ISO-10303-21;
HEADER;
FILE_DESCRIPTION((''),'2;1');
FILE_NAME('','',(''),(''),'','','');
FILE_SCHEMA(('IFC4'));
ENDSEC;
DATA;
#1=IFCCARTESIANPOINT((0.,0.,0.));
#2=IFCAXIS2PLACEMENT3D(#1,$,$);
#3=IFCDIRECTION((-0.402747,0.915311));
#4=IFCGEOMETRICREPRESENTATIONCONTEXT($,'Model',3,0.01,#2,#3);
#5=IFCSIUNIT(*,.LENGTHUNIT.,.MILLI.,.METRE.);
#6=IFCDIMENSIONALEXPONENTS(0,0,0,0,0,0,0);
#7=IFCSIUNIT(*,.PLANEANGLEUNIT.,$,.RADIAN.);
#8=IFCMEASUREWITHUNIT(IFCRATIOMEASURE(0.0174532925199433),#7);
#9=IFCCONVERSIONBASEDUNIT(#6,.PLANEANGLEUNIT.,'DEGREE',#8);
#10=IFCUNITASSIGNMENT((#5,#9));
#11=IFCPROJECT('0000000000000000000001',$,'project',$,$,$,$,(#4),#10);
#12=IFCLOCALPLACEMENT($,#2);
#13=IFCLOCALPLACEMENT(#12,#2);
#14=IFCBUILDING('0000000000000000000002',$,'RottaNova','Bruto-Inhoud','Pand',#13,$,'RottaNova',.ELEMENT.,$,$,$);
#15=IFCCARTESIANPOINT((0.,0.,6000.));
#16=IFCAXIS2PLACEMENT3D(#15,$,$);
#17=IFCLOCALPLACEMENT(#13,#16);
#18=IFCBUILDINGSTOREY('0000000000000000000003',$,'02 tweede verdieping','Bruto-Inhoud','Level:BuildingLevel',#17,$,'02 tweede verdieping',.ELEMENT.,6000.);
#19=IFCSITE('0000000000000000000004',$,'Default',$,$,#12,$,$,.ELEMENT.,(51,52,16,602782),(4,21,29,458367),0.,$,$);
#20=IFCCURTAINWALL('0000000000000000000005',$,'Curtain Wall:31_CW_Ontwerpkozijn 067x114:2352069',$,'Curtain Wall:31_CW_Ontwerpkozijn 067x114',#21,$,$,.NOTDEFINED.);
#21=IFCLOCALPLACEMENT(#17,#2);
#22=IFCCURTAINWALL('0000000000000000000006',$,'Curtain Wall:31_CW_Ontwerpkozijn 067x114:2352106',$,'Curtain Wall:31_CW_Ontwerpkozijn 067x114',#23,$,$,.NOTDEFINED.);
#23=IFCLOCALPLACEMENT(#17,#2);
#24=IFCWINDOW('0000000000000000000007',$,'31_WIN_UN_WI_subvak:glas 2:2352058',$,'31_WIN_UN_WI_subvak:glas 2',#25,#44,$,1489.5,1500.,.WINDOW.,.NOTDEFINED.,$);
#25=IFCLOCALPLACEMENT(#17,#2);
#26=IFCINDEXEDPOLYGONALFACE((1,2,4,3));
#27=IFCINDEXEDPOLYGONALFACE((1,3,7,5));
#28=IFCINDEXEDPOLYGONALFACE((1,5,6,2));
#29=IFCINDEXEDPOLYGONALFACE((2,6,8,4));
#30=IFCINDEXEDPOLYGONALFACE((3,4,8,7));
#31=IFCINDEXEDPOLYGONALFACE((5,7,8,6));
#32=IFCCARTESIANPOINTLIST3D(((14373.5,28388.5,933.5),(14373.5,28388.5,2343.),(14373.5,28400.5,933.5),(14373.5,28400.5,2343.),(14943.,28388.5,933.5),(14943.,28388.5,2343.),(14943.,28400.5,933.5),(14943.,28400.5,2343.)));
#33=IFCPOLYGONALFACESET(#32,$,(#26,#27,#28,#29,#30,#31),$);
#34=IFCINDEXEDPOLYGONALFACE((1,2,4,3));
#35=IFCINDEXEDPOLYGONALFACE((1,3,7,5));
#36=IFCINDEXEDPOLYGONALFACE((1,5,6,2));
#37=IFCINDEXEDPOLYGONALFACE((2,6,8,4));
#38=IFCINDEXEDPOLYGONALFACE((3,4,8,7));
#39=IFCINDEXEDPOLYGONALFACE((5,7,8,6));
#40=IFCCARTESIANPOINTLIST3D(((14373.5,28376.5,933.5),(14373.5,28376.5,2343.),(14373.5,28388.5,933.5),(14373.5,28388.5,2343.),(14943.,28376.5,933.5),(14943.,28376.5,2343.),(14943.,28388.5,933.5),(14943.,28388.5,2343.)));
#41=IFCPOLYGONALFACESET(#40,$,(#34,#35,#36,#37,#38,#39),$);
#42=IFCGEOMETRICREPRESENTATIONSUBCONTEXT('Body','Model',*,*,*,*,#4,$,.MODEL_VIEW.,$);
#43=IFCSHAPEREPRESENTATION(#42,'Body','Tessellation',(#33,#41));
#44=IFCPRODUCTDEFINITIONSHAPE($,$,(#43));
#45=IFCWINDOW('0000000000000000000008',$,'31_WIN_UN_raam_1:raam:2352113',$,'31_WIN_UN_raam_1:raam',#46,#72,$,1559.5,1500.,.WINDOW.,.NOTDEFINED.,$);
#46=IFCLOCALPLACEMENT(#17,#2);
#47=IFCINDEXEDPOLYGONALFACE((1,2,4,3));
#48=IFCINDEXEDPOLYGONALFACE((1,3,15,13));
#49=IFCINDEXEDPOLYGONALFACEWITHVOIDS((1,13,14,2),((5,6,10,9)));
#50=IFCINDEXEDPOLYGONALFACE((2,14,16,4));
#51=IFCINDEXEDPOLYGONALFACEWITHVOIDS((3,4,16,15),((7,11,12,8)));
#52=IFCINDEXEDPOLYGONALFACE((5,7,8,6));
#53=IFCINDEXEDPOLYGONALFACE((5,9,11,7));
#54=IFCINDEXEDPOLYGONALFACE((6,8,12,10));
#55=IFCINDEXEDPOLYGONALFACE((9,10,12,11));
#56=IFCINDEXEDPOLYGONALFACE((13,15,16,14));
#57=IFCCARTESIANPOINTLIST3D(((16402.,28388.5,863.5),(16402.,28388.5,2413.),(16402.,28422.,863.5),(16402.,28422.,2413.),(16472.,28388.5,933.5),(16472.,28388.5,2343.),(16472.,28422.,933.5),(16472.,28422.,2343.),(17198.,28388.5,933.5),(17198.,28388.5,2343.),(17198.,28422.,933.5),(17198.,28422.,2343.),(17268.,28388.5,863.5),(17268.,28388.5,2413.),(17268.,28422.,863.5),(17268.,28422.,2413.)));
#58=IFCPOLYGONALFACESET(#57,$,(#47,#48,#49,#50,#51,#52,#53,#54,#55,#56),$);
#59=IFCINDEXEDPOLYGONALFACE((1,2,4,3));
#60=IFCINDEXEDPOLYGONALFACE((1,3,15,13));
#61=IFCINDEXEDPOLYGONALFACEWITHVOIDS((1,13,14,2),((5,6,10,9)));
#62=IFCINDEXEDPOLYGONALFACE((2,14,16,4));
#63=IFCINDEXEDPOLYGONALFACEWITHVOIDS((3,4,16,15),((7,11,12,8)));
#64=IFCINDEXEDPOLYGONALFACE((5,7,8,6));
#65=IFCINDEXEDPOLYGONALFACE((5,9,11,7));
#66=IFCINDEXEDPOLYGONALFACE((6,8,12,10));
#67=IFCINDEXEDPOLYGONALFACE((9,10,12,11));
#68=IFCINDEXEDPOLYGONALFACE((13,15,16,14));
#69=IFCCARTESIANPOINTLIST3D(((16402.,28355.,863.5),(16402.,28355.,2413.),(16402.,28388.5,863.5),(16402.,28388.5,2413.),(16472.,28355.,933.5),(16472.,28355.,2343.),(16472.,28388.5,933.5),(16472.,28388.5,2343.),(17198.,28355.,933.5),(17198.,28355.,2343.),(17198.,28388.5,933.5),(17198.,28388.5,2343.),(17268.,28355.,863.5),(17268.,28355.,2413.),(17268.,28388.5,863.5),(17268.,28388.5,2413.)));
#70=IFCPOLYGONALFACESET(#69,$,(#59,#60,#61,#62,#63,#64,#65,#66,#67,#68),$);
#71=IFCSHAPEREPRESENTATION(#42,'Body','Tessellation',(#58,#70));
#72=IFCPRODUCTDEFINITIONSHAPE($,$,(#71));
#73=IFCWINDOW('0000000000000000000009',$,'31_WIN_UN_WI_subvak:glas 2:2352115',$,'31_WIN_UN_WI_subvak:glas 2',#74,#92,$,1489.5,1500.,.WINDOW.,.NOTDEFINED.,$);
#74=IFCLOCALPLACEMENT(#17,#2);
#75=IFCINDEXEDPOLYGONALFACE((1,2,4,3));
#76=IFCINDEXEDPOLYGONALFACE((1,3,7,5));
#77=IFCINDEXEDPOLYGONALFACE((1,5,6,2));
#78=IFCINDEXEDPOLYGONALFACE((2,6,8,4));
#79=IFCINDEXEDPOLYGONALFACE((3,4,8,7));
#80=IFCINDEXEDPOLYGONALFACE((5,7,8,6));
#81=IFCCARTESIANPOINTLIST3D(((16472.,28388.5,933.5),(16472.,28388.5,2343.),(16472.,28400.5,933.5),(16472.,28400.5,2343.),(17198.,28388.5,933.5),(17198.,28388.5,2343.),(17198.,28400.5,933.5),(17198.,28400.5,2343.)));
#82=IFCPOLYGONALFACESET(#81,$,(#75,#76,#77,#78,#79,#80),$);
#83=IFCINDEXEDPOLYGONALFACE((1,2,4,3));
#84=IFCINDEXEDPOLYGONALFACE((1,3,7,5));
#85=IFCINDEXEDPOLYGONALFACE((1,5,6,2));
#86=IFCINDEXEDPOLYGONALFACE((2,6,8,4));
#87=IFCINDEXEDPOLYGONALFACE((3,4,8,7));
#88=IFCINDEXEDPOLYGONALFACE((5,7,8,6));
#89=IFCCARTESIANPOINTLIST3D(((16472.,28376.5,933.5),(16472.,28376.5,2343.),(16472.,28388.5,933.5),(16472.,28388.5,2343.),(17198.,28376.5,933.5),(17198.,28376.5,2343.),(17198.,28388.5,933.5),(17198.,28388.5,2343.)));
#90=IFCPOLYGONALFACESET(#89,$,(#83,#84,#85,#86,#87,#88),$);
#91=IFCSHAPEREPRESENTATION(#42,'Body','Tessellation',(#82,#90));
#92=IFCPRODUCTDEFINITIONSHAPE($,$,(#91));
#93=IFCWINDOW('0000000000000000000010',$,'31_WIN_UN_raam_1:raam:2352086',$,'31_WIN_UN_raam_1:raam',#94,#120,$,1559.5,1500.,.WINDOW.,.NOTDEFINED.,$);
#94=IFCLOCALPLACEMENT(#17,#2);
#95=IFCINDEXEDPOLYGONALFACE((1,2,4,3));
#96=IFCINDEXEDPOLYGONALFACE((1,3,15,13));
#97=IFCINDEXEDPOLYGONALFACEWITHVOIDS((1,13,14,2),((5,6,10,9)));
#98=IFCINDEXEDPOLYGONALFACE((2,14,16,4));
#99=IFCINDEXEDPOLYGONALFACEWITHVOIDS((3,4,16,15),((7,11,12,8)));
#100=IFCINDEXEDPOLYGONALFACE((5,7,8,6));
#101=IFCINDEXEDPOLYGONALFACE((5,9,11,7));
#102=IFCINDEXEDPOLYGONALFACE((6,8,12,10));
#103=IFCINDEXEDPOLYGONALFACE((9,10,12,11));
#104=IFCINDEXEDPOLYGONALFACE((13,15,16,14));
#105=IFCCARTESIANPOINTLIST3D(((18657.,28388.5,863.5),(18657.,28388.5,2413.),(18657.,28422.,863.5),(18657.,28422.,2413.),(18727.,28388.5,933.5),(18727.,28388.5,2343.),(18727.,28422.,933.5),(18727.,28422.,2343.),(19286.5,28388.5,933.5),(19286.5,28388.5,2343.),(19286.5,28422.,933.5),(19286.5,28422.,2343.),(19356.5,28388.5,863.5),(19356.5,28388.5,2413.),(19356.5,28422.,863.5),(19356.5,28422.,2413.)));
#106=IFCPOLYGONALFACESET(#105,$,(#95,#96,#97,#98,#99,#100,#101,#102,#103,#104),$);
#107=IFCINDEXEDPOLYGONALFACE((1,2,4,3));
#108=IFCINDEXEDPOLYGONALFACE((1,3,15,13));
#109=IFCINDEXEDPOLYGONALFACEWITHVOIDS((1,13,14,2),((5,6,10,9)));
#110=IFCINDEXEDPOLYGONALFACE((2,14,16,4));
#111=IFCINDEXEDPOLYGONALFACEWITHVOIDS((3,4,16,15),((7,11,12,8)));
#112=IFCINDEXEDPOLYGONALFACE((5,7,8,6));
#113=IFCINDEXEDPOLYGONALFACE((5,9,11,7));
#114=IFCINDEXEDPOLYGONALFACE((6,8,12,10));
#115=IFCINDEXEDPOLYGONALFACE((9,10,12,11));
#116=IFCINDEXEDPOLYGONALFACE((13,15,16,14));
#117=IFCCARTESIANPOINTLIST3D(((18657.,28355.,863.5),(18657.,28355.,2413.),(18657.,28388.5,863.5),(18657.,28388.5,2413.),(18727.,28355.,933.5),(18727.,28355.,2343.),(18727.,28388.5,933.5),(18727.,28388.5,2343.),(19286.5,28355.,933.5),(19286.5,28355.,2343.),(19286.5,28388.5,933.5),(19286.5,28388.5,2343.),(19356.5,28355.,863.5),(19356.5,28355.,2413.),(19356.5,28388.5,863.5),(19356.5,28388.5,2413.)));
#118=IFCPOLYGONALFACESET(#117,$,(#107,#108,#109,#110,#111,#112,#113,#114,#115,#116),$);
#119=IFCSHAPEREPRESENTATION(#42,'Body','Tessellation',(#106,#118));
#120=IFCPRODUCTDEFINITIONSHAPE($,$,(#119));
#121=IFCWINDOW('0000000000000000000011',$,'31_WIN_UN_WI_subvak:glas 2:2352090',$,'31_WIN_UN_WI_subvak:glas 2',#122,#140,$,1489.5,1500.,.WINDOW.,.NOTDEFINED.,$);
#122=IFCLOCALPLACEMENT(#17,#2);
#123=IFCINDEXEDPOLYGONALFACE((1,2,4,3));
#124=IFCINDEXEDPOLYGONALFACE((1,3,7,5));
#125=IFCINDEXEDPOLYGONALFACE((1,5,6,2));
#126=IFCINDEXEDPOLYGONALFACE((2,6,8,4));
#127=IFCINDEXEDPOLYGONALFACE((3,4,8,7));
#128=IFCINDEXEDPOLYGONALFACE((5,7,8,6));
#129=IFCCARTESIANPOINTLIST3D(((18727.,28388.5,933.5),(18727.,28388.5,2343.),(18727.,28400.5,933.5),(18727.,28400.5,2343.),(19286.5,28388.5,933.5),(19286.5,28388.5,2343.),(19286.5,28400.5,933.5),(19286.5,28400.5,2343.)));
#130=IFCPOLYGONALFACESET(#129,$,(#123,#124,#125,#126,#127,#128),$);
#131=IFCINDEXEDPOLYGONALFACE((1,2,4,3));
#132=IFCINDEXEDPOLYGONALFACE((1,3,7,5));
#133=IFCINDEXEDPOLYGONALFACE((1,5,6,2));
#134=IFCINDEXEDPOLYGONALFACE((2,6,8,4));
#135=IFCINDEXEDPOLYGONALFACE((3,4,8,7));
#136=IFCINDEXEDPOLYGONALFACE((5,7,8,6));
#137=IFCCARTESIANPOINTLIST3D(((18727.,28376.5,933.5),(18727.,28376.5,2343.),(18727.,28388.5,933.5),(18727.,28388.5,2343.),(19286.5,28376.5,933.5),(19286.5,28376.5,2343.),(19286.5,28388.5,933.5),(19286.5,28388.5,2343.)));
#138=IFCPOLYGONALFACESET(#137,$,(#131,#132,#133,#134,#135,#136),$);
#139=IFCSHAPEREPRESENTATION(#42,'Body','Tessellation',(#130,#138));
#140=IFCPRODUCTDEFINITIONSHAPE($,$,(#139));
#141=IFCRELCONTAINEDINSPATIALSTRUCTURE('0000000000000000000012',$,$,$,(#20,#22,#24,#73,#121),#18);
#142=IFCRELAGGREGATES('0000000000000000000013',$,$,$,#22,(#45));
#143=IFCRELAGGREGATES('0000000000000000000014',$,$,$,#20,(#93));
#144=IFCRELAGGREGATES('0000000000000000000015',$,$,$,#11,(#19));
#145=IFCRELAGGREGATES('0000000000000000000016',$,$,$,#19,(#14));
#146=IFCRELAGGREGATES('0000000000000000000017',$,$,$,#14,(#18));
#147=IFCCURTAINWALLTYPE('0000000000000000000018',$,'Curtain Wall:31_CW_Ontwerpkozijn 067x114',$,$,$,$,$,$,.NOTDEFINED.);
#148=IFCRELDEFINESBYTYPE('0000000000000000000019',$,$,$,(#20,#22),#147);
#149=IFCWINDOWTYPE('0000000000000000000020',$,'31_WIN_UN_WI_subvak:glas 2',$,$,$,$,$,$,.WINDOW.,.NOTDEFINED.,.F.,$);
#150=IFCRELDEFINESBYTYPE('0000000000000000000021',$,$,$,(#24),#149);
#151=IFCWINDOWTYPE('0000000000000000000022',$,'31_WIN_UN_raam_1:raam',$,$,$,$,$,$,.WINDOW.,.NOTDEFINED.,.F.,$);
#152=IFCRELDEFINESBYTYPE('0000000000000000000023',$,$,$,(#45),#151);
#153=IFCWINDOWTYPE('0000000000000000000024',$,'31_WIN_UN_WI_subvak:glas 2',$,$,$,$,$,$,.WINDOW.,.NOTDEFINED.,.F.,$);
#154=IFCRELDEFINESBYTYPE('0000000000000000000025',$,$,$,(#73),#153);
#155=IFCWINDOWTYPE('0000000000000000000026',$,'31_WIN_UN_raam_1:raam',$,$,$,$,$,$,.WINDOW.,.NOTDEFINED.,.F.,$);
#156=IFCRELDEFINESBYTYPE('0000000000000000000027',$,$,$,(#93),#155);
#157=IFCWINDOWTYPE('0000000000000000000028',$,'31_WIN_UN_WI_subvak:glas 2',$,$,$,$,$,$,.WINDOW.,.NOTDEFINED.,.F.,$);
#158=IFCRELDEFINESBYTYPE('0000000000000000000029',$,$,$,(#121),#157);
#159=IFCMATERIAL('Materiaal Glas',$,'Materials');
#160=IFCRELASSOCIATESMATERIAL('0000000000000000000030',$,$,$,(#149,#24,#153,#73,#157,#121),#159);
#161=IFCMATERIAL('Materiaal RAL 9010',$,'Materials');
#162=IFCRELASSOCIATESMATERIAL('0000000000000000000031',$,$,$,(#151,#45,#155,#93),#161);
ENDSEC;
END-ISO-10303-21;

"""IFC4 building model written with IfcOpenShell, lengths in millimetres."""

from ifc_helpers import new_model, entity, si_unit, converted_unit, direction, frame, frame_2d, origin, origin_2d_with_axis, place, context, subcontext, project, spatial, polyline, rectangle, outline, extrude, source, transform, mapped, material, type_object, type_shapes, element, aggregate, save


model = new_model("IFC4")

# Units and contexts
model_context = context("Model", 3, precision=0.01, world=origin(), true_north=direction((-0.402747, 0.915311)))
body_context = subcontext(model_context, "Body", "Model", "MODEL_VIEW")
ifc_project = project(units=[si_unit("LENGTHUNIT", "METRE", prefix="MILLI"), converted_unit("PLANEANGLEUNIT", "DEGREE", entity("IfcRatioMeasure", 0.0174532925199433), si_unit("PLANEANGLEUNIT", "RADIAN"), dimensions=[0, 0, 0, 0, 0, 0, 0])], contexts=[model_context])

# Site, building, storey
site_placement = place(None, origin())
site = spatial("IfcSite", under=ifc_project, at=site_placement, Name="Default", CompositionType="ELEMENT", RefLatitude=(51, 52, 16, 602782), RefLongitude=(4, 21, 29, 458367), RefElevation=0.0)
building_placement = place(site_placement, origin())
building = spatial("IfcBuilding", under=site, at=building_placement, Name="RottaNova", Description="Bruto-Inhoud", ObjectType="Pand", LongName="RottaNova", CompositionType="ELEMENT")
storey_placement = place(building_placement, frame((0.0, 0.0, 6000.0)))
storey = spatial("IfcBuildingStorey", under=building, at=storey_placement, Name="02 tweede verdieping", Description="Bruto-Inhoud", ObjectType="Level:BuildingLevel", LongName="02 tweede verdieping", CompositionType="ELEMENT", Elevation=6000.0)

# Shared definitions
curtain_wall_type = type_object("IfcCurtainWallType", Name="Curtain Wall:31_CW_Ontwerpkozijn 067x114", PredefinedType="NOTDEFINED")

# Curtain wall
curtain_wall_1_placement = place(storey_placement, frame((0.0, 0.0, -6000.0)))
curtain_wall_1 = element("IfcCurtainWall", 1, at=curtain_wall_1_placement, inside=storey, type_object=curtain_wall_type, Name="Curtain Wall:31_CW_Ontwerpkozijn 067x114:2352069", ObjectType="Curtain Wall:31_CW_Ontwerpkozijn 067x114", PredefinedType="NOTDEFINED")

# Curtain wall
curtain_wall_2_placement = place(storey_placement, frame((0.0, 0.0, -6000.0)))
curtain_wall_2 = element("IfcCurtainWall", 2, at=curtain_wall_2_placement, inside=storey, type_object=curtain_wall_type, Name="Curtain Wall:31_CW_Ontwerpkozijn 067x114:2352106", ObjectType="Curtain Wall:31_CW_Ontwerpkozijn 067x114", PredefinedType="NOTDEFINED")

# Shared definitions
ifc_material_1 = material(Name="Materiaal Glas", Category="Materials")

# Windows
window_type_1 = type_object("IfcWindowType", Name="31_WIN_UN_WI_subvak:glas 2", ParameterTakesPrecedence=False, PartitioningType="NOTDEFINED", PredefinedType="WINDOW", material=ifc_material_1)
shared_shape_1 = source(origin(), body_context, "Body", "SweptSolid", [
    extrude(rectangle(XDim=12.0, YDim=569.5, at=origin_2d_with_axis()), frame((0.0, 6.0, 0.0), z_axis=(0.0, 0.0, 1.0), x_axis=(0.0, -1.0, 0.0)), (0.0, 0.0, 1.0), 1409.5),
    extrude(rectangle(XDim=12.0, YDim=569.5, at=frame_2d((0.0, 0.0), x_axis=(1.0, 0.0))), frame((0.0, -6.0, 0.0), z_axis=(0.0, 0.0, 1.0), x_axis=(0.0, -1.0, 0.0)), (0.0, 0.0, 1.0), 1409.5),
])
type_shapes(window_type_1, [shared_shape_1])
window_1_placement = place(storey_placement, frame((14658.3, 28388.5, 933.5)))
element("IfcWindow", 3, at=window_1_placement, inside=storey, type_object=window_type_1, material=ifc_material_1, Name="31_WIN_UN_WI_subvak:glas 2:2352058", ObjectType="31_WIN_UN_WI_subvak:glas 2", OverallHeight=1489.5, OverallWidth=1500.0, PartitioningType="NOTDEFINED", PredefinedType="WINDOW", context=body_context, shape_type="MappedRepresentation", body=[
    mapped(shared_shape_1, transform((0.0, 0.0, 0.0), scale=1.0)),
])
ifc_material_2 = material(Name="Materiaal RAL 9010", Category="Materials")
window_type_2 = type_object("IfcWindowType", Name="31_WIN_UN_raam_1:raam", ParameterTakesPrecedence=False, PartitioningType="NOTDEFINED", PredefinedType="WINDOW", material=ifc_material_2)
shared_shape_2 = source(origin(), body_context, "Body", "SweptSolid", [
    extrude(outline(polyline([(-433.0, -774.7), (433.0, -774.7), (433.0, 774.7), (-433.0, 774.7), (-433.0, -774.7)]), holes=[polyline([(-363.0, 704.7), (363.0, 704.7), (363.0, -704.8), (-363.0, -704.8), (-363.0, 704.7)])]), frame((0.0, 92.0, 774.8), z_axis=(0.0, -1.0, 0.0), x_axis=(-1.0, 0.0, 0.0)), (0.0, 0.0, 1.0), 33.5),
    extrude(outline(polyline([(-433.0, -774.7), (433.0, -774.7), (433.0, 774.7), (-433.0, 774.7), (-433.0, -774.7)]), holes=[polyline([(-363.0, 704.7), (363.0, 704.7), (363.0, -704.8), (-363.0, -704.8), (-363.0, 704.7)])]), frame((0.0, 58.5, 774.8), z_axis=(0.0, -1.0, 0.0), x_axis=(-1.0, 0.0, 0.0)), (0.0, 0.0, 1.0), 33.5),
])
type_shapes(window_type_2, [shared_shape_2])
window_2_placement = place(curtain_wall_2_placement, frame((16835.0, 28330.0, 6863.5)))
window_2 = element("IfcWindow", 4, at=window_2_placement, type_object=window_type_2, material=ifc_material_2, Name="31_WIN_UN_raam_1:raam:2352113", ObjectType="31_WIN_UN_raam_1:raam", OverallHeight=1559.5, OverallWidth=1500.0, PartitioningType="NOTDEFINED", PredefinedType="WINDOW", context=body_context, shape_type="MappedRepresentation", body=[
    mapped(shared_shape_2, transform((0.0, 0.0, 0.0), scale=1.0)),
])
aggregate(curtain_wall_2, [window_2])
window_type_3 = type_object("IfcWindowType", Name="31_WIN_UN_WI_subvak:glas 2", ParameterTakesPrecedence=False, PartitioningType="NOTDEFINED", PredefinedType="WINDOW", material=ifc_material_1)
shared_shape_3 = source(origin(), body_context, "Body", "SweptSolid", [
    extrude(rectangle(XDim=726.0, YDim=12.0, at=origin_2d_with_axis()), frame((0.0, -6.0, 0.0)), (0.0, 0.0, 1.0), 1409.5),
    extrude(rectangle(XDim=726.0, YDim=12.0, at=origin_2d_with_axis()), frame((0.0, 6.0, 0.0)), (0.0, 0.0, 1.0), 1409.5),
])
type_shapes(window_type_3, [shared_shape_3])
window_3_placement = place(storey_placement, frame((16835.0, 28388.5, 933.5), z_axis=(0.0, 0.0, 1.0), x_axis=(-1.0, 0.0, 0.0)))
element("IfcWindow", 5, at=window_3_placement, inside=storey, type_object=window_type_3, material=ifc_material_1, Name="31_WIN_UN_WI_subvak:glas 2:2352115", ObjectType="31_WIN_UN_WI_subvak:glas 2", OverallHeight=1489.5, OverallWidth=1500.0, PartitioningType="NOTDEFINED", PredefinedType="WINDOW", context=body_context, shape_type="MappedRepresentation", body=[
    mapped(shared_shape_3, transform((0.0, 0.0, 0.0), scale=1.0)),
])
window_type_4 = type_object("IfcWindowType", Name="31_WIN_UN_raam_1:raam", ParameterTakesPrecedence=False, PartitioningType="NOTDEFINED", PredefinedType="WINDOW", material=ifc_material_2)
shared_shape_4 = source(origin(), body_context, "Body", "SweptSolid", [
    extrude(outline(polyline([(-349.7, -774.8), (349.7, -774.8), (349.7, 774.8), (-349.7, 774.8), (-349.7, -774.8)]), holes=[polyline([(-279.7, 704.8), (279.7, 704.8), (279.7, -704.8), (-279.7, -704.8), (-279.7, 704.8)])]), frame((0.0, 58.5, 774.8), z_axis=(0.0, 1.0, 0.0), x_axis=(1.0, 0.0, 0.0)), (0.0, 0.0, 1.0), 33.5),
    extrude(outline(polyline([(-349.7, -774.8), (349.7, -774.8), (349.7, 774.8), (-349.7, 774.8), (-349.7, -774.8)]), holes=[polyline([(-279.7, 704.7), (279.7, 704.7), (279.7, -704.8), (-279.7, -704.8), (-279.7, 704.7)])]), frame((0.0, 25.0, 774.8), z_axis=(0.0, 1.0, 0.0), x_axis=(1.0, 0.0, 0.0)), (0.0, 0.0, 1.0), 33.5),
])
type_shapes(window_type_4, [shared_shape_4])
window_4_placement = place(curtain_wall_1_placement, frame((19006.8, 28330.0, 6863.5)))
window_4 = element("IfcWindow", 6, at=window_4_placement, type_object=window_type_4, material=ifc_material_2, Name="31_WIN_UN_raam_1:raam:2352086", ObjectType="31_WIN_UN_raam_1:raam", OverallHeight=1559.5, OverallWidth=1500.0, PartitioningType="NOTDEFINED", PredefinedType="WINDOW", context=body_context, shape_type="MappedRepresentation", body=[
    mapped(shared_shape_4, transform((0.0, 0.0, 0.0), scale=1.0)),
])
aggregate(curtain_wall_1, [window_4])
window_type_5 = type_object("IfcWindowType", Name="31_WIN_UN_WI_subvak:glas 2", ParameterTakesPrecedence=False, PartitioningType="NOTDEFINED", PredefinedType="WINDOW", material=ifc_material_1)
shared_shape_5 = source(origin(), body_context, "Body", "SweptSolid", [
    extrude(rectangle(XDim=12.0, YDim=559.5, at=frame_2d((0.0, 0.0), x_axis=(1.0, 0.0))), frame((0.0, 6.0, 0.0), z_axis=(0.0, 0.0, 1.0), x_axis=(0.0, -1.0, 0.0)), (0.0, 0.0, 1.0), 1409.5),
    extrude(rectangle(XDim=12.0, YDim=559.5, at=origin_2d_with_axis()), frame((0.0, -6.0, 0.0), z_axis=(0.0, 0.0, 1.0), x_axis=(0.0, -1.0, 0.0)), (0.0, 0.0, 1.0), 1409.5),
])
type_shapes(window_type_5, [shared_shape_5])
window_5_placement = place(storey_placement, frame((19006.8, 28388.5, 933.5)))
element("IfcWindow", 7, at=window_5_placement, inside=storey, type_object=window_type_5, material=ifc_material_1, Name="31_WIN_UN_WI_subvak:glas 2:2352090", ObjectType="31_WIN_UN_WI_subvak:glas 2", OverallHeight=1489.5, OverallWidth=1500.0, PartitioningType="NOTDEFINED", PredefinedType="WINDOW", context=body_context, shape_type="MappedRepresentation", body=[
    mapped(shared_shape_5, transform((0.0, 0.0, 0.0), scale=1.0)),
])

save(model, "model.ifc")
